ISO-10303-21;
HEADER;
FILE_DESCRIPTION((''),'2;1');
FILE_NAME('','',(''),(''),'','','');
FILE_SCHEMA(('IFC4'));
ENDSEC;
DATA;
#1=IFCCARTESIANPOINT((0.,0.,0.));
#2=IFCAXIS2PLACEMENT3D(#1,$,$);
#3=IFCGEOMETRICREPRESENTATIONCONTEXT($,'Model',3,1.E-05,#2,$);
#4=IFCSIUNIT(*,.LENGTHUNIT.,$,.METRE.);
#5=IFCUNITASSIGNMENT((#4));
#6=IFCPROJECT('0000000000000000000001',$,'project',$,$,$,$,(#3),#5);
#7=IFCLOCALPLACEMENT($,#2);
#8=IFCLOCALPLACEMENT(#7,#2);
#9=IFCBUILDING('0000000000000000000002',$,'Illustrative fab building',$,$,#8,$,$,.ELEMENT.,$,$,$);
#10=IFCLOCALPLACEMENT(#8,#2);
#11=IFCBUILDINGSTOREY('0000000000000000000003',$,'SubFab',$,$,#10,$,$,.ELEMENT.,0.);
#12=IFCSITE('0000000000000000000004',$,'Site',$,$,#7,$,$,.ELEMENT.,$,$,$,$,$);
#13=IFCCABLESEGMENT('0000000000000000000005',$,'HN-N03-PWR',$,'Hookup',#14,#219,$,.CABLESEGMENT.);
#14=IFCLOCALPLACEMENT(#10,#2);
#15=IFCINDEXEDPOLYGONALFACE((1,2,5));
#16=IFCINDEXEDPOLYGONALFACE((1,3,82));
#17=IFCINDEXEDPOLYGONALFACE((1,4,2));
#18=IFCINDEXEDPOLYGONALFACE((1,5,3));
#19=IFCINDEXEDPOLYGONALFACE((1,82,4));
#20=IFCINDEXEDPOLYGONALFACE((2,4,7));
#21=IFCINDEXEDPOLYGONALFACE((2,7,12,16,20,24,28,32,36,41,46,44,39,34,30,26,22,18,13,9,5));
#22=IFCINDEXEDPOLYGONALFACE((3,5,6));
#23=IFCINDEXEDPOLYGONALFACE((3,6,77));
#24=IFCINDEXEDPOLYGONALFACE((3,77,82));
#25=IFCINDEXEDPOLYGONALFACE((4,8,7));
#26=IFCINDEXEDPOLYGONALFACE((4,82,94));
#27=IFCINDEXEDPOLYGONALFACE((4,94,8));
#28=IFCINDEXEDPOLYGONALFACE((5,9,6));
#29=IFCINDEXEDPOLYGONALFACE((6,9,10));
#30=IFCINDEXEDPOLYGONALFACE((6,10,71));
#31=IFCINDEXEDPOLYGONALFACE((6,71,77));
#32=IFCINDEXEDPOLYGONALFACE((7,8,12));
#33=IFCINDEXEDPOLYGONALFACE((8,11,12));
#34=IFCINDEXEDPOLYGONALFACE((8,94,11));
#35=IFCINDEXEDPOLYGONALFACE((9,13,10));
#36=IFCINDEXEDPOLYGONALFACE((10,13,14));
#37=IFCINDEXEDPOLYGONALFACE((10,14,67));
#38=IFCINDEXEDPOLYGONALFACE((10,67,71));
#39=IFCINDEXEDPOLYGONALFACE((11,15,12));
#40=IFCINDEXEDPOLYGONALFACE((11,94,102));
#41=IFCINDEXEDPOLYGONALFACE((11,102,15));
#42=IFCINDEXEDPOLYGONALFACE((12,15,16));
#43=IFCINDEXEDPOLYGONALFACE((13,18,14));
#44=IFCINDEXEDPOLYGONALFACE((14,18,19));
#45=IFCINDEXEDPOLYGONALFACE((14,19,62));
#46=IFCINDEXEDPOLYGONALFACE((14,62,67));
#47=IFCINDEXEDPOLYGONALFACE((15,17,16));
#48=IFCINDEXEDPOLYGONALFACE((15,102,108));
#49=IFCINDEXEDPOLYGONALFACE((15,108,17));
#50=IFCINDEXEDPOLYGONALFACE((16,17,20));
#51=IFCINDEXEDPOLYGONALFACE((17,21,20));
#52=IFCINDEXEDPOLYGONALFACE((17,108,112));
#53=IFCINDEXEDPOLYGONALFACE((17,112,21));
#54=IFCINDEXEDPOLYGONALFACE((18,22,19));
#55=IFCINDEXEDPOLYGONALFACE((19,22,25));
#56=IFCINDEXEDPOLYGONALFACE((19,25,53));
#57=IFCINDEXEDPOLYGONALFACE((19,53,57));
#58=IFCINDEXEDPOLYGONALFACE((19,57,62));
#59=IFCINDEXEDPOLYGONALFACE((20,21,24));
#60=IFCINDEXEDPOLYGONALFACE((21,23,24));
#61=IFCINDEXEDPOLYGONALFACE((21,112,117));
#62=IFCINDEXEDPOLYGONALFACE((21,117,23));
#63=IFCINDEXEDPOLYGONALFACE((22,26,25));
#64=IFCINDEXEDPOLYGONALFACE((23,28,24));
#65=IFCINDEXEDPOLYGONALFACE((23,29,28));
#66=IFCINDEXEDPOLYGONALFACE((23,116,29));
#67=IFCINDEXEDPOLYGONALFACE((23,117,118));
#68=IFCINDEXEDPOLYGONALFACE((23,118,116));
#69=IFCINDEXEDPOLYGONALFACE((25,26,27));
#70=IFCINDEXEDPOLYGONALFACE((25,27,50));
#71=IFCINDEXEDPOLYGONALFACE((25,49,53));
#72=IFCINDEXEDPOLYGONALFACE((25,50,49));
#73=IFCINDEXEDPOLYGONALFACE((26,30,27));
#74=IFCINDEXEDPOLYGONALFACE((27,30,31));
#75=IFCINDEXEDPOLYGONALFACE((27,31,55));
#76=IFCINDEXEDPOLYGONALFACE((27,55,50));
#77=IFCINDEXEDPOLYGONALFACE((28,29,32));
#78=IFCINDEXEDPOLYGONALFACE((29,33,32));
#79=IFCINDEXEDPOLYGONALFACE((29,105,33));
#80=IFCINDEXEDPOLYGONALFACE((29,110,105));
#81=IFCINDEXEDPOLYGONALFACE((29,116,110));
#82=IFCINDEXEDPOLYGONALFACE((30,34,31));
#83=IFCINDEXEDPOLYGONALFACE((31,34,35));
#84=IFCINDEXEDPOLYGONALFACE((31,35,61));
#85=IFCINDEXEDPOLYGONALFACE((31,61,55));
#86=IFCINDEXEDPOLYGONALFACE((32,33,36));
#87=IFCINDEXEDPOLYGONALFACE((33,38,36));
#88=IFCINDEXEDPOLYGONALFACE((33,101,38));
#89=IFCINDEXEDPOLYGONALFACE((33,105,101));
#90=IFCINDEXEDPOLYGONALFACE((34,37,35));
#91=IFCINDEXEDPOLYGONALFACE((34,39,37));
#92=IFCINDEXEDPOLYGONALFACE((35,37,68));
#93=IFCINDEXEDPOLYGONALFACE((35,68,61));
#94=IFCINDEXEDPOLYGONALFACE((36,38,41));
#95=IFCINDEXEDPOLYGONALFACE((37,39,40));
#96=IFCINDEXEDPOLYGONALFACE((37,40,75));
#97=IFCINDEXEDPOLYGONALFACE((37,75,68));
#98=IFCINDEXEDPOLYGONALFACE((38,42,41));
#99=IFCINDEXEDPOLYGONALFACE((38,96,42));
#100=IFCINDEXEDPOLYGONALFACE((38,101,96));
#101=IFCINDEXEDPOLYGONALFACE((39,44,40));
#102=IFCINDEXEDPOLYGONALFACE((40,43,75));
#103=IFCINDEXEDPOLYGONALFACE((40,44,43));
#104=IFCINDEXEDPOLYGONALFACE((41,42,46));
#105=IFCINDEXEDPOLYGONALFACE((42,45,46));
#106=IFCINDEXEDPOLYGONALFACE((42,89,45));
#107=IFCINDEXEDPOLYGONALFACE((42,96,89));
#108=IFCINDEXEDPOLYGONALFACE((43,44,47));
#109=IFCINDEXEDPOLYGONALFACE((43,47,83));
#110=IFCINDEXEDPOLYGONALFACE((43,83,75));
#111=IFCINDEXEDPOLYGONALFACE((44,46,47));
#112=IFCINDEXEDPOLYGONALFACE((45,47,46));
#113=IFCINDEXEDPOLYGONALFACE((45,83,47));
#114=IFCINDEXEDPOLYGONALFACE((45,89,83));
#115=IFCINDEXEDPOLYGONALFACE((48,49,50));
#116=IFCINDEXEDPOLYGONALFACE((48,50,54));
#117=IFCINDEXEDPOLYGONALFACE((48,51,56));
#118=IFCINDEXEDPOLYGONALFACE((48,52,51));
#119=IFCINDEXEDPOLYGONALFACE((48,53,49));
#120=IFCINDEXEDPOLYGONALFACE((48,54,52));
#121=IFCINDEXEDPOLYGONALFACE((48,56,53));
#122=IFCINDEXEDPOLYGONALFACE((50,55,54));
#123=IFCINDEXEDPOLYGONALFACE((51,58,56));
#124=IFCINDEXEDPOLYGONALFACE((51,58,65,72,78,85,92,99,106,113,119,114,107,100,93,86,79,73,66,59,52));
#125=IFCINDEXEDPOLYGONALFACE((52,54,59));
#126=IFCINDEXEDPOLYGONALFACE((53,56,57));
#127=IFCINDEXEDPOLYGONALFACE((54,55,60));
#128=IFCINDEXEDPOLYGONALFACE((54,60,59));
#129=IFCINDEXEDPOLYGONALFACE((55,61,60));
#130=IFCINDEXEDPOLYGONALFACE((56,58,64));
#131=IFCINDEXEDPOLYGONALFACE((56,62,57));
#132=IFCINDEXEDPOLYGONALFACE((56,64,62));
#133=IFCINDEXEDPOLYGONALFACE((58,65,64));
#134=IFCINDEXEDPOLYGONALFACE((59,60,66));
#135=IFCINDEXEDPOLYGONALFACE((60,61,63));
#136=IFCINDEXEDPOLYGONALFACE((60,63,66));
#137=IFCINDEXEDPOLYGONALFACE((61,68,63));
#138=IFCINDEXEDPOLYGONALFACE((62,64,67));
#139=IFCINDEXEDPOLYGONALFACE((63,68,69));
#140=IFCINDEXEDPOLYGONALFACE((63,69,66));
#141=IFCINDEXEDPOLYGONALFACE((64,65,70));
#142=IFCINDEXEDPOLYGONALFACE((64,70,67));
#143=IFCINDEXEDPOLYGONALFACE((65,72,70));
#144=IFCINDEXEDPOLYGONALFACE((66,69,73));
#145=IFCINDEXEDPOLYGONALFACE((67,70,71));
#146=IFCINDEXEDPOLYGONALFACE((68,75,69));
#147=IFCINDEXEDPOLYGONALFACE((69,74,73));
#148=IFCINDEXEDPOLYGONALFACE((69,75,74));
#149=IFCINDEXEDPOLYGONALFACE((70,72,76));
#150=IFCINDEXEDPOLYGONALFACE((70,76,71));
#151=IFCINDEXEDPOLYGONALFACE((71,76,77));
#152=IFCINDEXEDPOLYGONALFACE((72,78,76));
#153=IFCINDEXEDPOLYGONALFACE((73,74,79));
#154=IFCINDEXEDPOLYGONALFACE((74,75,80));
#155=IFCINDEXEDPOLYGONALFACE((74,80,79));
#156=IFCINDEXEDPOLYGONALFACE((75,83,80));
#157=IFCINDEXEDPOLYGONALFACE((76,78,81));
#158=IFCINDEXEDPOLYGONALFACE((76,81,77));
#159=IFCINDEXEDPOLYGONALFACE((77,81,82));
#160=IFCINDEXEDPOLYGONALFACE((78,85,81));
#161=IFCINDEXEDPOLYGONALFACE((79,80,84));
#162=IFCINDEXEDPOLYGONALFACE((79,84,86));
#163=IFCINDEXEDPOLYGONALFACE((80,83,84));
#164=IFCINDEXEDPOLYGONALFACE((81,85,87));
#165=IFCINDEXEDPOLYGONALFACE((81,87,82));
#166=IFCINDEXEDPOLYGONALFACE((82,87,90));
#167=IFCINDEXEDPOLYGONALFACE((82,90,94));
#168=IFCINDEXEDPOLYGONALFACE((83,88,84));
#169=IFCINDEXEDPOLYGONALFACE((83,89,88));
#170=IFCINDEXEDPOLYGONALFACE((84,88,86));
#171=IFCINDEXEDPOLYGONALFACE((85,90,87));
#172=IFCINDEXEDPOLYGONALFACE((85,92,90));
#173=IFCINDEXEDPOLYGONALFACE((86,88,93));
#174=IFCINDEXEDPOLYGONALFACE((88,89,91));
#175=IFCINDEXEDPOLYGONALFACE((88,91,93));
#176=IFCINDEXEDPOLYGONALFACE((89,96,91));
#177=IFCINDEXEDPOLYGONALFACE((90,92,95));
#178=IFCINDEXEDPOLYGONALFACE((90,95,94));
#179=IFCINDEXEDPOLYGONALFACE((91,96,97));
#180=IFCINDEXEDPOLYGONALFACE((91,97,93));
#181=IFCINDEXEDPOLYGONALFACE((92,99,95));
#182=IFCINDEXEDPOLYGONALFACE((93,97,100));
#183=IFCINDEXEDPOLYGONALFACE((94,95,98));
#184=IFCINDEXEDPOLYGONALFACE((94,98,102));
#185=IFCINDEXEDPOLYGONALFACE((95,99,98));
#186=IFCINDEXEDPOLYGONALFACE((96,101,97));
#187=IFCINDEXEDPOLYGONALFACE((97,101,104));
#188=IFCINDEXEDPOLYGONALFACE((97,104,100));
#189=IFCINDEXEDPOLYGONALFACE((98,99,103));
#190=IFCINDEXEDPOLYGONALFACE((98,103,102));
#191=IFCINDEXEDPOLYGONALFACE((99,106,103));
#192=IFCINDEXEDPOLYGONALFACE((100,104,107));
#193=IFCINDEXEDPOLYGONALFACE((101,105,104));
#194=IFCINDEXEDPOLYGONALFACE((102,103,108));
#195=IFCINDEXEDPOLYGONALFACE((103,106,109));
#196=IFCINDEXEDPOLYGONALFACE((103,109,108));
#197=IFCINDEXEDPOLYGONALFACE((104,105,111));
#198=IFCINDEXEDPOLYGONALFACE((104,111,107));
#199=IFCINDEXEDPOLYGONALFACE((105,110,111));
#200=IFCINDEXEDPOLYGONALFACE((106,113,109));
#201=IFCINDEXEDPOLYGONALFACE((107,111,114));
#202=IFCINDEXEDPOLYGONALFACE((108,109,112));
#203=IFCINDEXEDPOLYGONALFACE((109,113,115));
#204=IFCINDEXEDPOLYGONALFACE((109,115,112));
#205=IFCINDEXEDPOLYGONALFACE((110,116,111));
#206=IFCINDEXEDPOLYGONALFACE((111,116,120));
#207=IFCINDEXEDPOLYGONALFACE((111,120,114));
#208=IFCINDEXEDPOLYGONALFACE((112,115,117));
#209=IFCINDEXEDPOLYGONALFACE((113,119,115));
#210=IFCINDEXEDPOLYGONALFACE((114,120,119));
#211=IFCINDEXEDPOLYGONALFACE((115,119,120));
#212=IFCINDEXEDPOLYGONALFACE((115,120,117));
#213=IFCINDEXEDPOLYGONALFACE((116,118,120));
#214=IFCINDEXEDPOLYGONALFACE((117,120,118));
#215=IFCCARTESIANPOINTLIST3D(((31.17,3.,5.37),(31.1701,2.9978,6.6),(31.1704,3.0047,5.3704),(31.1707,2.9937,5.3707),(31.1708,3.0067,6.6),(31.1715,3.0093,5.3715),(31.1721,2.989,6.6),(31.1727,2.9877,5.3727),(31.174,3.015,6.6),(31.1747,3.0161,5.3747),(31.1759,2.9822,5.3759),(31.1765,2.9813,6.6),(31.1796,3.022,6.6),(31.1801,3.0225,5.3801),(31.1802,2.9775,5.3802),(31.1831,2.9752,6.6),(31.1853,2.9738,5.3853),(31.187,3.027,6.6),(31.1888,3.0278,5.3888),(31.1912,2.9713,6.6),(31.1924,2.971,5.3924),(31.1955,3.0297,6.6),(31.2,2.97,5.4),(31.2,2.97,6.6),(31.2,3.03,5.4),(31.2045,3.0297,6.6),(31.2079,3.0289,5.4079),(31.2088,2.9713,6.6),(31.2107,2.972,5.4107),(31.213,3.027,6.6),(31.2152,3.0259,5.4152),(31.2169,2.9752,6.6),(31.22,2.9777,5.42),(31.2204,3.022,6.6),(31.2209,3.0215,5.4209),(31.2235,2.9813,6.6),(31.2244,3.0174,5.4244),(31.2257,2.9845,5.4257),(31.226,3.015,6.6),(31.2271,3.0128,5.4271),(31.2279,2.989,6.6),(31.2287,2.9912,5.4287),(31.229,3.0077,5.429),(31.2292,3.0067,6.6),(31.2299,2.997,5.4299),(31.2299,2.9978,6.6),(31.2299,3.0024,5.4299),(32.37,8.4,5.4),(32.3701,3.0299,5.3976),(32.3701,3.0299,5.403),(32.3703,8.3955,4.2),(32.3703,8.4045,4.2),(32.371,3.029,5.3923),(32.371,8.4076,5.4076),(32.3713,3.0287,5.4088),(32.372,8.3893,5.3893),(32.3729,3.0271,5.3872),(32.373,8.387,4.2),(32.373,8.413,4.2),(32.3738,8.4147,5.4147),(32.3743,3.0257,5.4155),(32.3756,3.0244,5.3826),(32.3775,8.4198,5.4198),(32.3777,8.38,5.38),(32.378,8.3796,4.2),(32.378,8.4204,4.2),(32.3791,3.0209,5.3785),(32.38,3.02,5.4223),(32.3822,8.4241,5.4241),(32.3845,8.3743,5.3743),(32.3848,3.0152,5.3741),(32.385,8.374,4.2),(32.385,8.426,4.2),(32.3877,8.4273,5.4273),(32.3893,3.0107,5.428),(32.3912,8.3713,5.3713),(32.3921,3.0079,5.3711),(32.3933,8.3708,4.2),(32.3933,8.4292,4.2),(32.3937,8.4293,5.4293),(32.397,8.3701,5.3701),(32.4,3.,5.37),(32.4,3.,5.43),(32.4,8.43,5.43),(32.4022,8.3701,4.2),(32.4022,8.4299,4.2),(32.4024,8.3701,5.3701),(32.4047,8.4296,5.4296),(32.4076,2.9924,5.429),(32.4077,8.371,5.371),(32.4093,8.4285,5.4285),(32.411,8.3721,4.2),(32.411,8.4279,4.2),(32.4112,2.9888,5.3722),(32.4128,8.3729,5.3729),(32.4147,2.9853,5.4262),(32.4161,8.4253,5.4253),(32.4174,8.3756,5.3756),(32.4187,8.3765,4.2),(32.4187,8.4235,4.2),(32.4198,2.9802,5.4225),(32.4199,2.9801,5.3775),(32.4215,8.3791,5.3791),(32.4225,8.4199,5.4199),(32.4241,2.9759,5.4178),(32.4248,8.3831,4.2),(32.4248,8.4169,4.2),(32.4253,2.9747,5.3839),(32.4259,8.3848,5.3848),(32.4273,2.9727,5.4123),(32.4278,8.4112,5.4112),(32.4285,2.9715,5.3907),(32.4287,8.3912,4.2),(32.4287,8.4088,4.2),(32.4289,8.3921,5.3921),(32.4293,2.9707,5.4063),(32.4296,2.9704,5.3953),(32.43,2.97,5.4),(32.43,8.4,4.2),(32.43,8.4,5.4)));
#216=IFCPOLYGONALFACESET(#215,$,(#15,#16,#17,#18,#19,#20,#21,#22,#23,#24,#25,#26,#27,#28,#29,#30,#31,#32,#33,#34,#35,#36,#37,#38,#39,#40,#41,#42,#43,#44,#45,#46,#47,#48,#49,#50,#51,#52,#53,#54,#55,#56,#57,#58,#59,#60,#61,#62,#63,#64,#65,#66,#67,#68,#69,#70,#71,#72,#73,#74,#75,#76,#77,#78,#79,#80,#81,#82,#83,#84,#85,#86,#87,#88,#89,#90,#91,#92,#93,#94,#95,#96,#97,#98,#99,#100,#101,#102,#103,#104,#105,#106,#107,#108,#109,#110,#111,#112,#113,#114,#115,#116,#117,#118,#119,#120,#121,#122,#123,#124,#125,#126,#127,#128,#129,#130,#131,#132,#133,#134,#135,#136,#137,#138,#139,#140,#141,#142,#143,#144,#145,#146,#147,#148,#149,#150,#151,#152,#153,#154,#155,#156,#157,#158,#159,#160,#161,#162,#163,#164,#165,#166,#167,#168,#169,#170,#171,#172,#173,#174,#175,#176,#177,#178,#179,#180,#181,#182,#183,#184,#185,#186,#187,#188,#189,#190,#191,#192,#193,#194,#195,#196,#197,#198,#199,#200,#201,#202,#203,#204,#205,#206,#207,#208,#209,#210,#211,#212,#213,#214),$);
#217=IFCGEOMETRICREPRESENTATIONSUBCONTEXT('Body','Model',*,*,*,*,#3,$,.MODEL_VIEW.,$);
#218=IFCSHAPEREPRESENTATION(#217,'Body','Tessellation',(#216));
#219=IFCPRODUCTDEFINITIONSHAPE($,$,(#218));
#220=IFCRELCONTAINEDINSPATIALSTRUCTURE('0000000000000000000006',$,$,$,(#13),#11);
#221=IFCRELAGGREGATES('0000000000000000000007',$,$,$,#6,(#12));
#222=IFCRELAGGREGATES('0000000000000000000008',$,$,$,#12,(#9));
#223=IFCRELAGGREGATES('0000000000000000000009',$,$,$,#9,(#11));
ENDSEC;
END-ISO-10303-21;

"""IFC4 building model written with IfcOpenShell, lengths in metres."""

from ifc_helpers import new_model, entity, si_unit, origin, place, context, subcontext, project, spatial, element, save


model = new_model("IFC4")

# Units and contexts
model_context = context("Model", 3, precision=1e-05, world=origin())
body_context = subcontext(model_context, "Body", "Model", "MODEL_VIEW")
ifc_project = project(units=[si_unit("LENGTHUNIT", "METRE")], contexts=[model_context])

# Site, building, storey
site_placement = place(None, origin())
site = spatial("IfcSite", under=ifc_project, at=site_placement, Name="Site", CompositionType="ELEMENT")
building_placement = place(site_placement, origin())
building = spatial("IfcBuilding", under=site, at=building_placement, Name="Illustrative fab building", CompositionType="ELEMENT")
storey_placement = place(building_placement, origin())
storey = spatial("IfcBuildingStorey", under=building, at=storey_placement, Name="SubFab", CompositionType="ELEMENT", Elevation=0.0)

# Cable segment
cable_segment_1_placement = place(storey_placement, origin())
element("IfcCableSegment", 1, at=cable_segment_1_placement, inside=storey, Name="HN-N03-PWR", ObjectType="Hookup", PredefinedType="CABLESEGMENT", context=body_context, shape_type="AdvancedSweptSolid", body=[
    entity("IfcSweptDiskSolid", entity("IfcPolyline", [entity("IfcCartesianPoint", [32.4, 8.4, 4.2]), entity("IfcCartesianPoint", [32.4, 8.4, 5.4]), entity("IfcCartesianPoint", [32.4, 3.0, 5.4]), entity("IfcCartesianPoint", [31.2, 3.0, 5.4]), entity("IfcCartesianPoint", [31.2, 3.0, 6.6])]), 0.03),
])

save(model, "model.ifc")
